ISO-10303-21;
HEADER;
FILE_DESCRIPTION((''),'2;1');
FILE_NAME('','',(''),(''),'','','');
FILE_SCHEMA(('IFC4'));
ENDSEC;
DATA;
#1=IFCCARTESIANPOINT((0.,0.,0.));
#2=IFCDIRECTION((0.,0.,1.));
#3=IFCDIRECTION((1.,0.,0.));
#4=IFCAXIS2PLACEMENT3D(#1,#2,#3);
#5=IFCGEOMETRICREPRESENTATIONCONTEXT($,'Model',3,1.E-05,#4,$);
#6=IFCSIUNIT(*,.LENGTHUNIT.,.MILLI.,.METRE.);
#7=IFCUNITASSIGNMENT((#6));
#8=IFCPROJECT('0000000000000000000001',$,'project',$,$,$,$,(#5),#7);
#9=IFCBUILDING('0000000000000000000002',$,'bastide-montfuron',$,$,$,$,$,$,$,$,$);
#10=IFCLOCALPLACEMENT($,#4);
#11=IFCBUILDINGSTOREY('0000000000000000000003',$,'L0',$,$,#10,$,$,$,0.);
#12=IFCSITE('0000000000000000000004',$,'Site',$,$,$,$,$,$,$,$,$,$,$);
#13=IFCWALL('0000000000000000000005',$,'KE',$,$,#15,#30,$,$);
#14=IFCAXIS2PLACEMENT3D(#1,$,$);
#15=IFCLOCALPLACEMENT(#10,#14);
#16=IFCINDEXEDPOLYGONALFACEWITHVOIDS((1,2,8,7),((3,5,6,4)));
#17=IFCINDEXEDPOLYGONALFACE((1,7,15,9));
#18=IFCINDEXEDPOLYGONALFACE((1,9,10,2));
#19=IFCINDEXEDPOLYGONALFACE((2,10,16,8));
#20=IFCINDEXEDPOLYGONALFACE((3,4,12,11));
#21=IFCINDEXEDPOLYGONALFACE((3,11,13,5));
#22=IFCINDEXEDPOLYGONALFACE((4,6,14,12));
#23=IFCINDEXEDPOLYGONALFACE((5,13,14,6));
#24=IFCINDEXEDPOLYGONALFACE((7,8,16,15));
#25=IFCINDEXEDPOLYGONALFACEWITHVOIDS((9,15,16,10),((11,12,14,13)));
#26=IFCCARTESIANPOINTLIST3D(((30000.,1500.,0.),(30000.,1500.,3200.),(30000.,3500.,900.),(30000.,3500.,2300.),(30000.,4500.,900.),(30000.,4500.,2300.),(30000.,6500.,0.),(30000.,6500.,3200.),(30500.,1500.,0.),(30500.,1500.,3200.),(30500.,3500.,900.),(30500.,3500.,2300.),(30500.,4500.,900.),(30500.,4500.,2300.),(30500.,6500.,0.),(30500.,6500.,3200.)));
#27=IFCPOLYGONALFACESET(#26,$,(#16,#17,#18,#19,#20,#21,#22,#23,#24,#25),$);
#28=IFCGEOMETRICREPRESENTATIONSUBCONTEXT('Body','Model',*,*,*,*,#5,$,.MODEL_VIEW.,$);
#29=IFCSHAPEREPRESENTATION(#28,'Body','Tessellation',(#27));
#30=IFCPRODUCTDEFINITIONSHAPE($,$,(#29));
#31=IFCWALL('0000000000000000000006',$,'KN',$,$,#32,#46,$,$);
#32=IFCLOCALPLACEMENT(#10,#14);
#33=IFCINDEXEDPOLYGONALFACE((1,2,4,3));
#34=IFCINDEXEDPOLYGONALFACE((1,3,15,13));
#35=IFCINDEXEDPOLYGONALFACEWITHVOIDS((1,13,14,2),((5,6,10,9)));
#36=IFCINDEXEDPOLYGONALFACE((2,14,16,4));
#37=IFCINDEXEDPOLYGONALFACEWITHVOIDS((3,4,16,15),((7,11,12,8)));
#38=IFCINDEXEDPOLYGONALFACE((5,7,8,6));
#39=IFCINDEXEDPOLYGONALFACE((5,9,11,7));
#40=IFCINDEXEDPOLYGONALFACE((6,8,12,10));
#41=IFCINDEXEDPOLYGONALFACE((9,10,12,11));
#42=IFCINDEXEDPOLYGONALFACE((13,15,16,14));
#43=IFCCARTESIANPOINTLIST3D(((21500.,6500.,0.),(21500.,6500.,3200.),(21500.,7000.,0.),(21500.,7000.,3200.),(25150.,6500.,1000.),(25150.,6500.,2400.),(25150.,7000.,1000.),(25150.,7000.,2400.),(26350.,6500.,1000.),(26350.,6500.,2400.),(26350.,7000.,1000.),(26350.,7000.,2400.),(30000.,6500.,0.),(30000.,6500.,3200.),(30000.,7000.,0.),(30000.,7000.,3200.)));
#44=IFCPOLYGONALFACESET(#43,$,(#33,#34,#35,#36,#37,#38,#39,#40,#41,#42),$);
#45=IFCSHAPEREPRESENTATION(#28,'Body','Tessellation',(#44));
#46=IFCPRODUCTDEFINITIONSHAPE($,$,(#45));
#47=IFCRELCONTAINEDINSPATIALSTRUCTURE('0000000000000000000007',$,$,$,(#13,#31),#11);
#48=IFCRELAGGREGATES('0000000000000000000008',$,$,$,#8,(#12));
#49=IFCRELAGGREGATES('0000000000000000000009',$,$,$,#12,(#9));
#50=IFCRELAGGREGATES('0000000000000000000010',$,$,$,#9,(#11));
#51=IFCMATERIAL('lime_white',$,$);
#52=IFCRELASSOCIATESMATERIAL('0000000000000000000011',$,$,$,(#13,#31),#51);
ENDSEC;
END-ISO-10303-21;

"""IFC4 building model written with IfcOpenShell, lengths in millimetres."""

from ifc_helpers import new_model, si_unit, frame, origin_with_axes, place, context, subcontext, project, spatial, indexed_curve, outline, extrude, material, element, save


model = new_model("IFC4")

# Units and contexts
model_context = context("Model", 3, precision=1e-05, world=origin_with_axes())
body_context = subcontext(model_context, "Body", "Model", "MODEL_VIEW")
ifc_project = project(units=[si_unit("LENGTHUNIT", "METRE", prefix="MILLI")], contexts=[model_context])

# Site, building, storey
site = spatial("IfcSite", under=ifc_project, Name="Site")
building = spatial("IfcBuilding", under=site, Name="bastide-montfuron")
storey_placement = place(None, origin_with_axes())
storey = spatial("IfcBuildingStorey", under=building, at=storey_placement, Name="L0", Elevation=0.0)

# Shared definitions
ifc_material = material(Name="lime_white")

# Walls, openings
wall_1_placement = place(storey_placement, frame((30500.0, 1500.0, 0.0), z_axis=(0.0, 0.0, 1.0), x_axis=(0.0, 1.0, 0.0)))
wall_1 = element("IfcWall", 1, at=wall_1_placement, inside=storey, material=ifc_material, Name="KE", context=body_context, shape_type="SweptSolid", body=[
    extrude(outline(indexed_curve([(0.0, 0.0), (0.0, 500.0), (5000.0, 500.0), (5000.0, 0.0), (0.0, 0.0)], self_intersect=False)), origin_with_axes(), (0.0, 0.0, 1.0), 3200.0),
])
opening_1_placement = place(wall_1_placement, frame((2000.0, -100.0, 900.0), z_axis=(0.0, 0.0, 1.0), x_axis=(1.0, 0.0, 0.0)))
element("IfcOpeningElement", 2, at=opening_1_placement, cuts=wall_1, context=body_context, shape_type="SweptSolid", body=[
    extrude(outline(indexed_curve([(0.0, 0.0), (0.0, 700.0), (1000.0, 700.0), (1000.0, 0.0), (0.0, 0.0)], self_intersect=False)), origin_with_axes(), (0.0, 0.0, 1.0), 1400.0),
])
wall_2_placement = place(storey_placement, frame((30000.0, 7000.0, 0.0), z_axis=(0.0, 0.0, 1.0), x_axis=(-1.0, 0.0, 0.0)))
wall_2 = element("IfcWall", 3, at=wall_2_placement, inside=storey, material=ifc_material, Name="KN", context=body_context, shape_type="SweptSolid", body=[
    extrude(outline(indexed_curve([(0.0, 0.0), (0.0, 500.0), (8500.0, 500.0), (8500.0, 0.0), (0.0, 0.0)], self_intersect=False)), origin_with_axes(), (0.0, 0.0, 1.0), 3200.0),
])
opening_2_placement = place(wall_2_placement, frame((3650.0, -100.0, 1000.0), z_axis=(0.0, 0.0, 1.0), x_axis=(1.0, 0.0, 0.0)))
element("IfcOpeningElement", 4, at=opening_2_placement, cuts=wall_2, context=body_context, shape_type="SweptSolid", body=[
    extrude(outline(indexed_curve([(0.0, 0.0), (0.0, 700.0), (1200.0, 700.0), (1200.0, 0.0), (0.0, 0.0)], self_intersect=False)), origin_with_axes(), (0.0, 0.0, 1.0), 1400.0),
])

save(model, "model.ifc")
